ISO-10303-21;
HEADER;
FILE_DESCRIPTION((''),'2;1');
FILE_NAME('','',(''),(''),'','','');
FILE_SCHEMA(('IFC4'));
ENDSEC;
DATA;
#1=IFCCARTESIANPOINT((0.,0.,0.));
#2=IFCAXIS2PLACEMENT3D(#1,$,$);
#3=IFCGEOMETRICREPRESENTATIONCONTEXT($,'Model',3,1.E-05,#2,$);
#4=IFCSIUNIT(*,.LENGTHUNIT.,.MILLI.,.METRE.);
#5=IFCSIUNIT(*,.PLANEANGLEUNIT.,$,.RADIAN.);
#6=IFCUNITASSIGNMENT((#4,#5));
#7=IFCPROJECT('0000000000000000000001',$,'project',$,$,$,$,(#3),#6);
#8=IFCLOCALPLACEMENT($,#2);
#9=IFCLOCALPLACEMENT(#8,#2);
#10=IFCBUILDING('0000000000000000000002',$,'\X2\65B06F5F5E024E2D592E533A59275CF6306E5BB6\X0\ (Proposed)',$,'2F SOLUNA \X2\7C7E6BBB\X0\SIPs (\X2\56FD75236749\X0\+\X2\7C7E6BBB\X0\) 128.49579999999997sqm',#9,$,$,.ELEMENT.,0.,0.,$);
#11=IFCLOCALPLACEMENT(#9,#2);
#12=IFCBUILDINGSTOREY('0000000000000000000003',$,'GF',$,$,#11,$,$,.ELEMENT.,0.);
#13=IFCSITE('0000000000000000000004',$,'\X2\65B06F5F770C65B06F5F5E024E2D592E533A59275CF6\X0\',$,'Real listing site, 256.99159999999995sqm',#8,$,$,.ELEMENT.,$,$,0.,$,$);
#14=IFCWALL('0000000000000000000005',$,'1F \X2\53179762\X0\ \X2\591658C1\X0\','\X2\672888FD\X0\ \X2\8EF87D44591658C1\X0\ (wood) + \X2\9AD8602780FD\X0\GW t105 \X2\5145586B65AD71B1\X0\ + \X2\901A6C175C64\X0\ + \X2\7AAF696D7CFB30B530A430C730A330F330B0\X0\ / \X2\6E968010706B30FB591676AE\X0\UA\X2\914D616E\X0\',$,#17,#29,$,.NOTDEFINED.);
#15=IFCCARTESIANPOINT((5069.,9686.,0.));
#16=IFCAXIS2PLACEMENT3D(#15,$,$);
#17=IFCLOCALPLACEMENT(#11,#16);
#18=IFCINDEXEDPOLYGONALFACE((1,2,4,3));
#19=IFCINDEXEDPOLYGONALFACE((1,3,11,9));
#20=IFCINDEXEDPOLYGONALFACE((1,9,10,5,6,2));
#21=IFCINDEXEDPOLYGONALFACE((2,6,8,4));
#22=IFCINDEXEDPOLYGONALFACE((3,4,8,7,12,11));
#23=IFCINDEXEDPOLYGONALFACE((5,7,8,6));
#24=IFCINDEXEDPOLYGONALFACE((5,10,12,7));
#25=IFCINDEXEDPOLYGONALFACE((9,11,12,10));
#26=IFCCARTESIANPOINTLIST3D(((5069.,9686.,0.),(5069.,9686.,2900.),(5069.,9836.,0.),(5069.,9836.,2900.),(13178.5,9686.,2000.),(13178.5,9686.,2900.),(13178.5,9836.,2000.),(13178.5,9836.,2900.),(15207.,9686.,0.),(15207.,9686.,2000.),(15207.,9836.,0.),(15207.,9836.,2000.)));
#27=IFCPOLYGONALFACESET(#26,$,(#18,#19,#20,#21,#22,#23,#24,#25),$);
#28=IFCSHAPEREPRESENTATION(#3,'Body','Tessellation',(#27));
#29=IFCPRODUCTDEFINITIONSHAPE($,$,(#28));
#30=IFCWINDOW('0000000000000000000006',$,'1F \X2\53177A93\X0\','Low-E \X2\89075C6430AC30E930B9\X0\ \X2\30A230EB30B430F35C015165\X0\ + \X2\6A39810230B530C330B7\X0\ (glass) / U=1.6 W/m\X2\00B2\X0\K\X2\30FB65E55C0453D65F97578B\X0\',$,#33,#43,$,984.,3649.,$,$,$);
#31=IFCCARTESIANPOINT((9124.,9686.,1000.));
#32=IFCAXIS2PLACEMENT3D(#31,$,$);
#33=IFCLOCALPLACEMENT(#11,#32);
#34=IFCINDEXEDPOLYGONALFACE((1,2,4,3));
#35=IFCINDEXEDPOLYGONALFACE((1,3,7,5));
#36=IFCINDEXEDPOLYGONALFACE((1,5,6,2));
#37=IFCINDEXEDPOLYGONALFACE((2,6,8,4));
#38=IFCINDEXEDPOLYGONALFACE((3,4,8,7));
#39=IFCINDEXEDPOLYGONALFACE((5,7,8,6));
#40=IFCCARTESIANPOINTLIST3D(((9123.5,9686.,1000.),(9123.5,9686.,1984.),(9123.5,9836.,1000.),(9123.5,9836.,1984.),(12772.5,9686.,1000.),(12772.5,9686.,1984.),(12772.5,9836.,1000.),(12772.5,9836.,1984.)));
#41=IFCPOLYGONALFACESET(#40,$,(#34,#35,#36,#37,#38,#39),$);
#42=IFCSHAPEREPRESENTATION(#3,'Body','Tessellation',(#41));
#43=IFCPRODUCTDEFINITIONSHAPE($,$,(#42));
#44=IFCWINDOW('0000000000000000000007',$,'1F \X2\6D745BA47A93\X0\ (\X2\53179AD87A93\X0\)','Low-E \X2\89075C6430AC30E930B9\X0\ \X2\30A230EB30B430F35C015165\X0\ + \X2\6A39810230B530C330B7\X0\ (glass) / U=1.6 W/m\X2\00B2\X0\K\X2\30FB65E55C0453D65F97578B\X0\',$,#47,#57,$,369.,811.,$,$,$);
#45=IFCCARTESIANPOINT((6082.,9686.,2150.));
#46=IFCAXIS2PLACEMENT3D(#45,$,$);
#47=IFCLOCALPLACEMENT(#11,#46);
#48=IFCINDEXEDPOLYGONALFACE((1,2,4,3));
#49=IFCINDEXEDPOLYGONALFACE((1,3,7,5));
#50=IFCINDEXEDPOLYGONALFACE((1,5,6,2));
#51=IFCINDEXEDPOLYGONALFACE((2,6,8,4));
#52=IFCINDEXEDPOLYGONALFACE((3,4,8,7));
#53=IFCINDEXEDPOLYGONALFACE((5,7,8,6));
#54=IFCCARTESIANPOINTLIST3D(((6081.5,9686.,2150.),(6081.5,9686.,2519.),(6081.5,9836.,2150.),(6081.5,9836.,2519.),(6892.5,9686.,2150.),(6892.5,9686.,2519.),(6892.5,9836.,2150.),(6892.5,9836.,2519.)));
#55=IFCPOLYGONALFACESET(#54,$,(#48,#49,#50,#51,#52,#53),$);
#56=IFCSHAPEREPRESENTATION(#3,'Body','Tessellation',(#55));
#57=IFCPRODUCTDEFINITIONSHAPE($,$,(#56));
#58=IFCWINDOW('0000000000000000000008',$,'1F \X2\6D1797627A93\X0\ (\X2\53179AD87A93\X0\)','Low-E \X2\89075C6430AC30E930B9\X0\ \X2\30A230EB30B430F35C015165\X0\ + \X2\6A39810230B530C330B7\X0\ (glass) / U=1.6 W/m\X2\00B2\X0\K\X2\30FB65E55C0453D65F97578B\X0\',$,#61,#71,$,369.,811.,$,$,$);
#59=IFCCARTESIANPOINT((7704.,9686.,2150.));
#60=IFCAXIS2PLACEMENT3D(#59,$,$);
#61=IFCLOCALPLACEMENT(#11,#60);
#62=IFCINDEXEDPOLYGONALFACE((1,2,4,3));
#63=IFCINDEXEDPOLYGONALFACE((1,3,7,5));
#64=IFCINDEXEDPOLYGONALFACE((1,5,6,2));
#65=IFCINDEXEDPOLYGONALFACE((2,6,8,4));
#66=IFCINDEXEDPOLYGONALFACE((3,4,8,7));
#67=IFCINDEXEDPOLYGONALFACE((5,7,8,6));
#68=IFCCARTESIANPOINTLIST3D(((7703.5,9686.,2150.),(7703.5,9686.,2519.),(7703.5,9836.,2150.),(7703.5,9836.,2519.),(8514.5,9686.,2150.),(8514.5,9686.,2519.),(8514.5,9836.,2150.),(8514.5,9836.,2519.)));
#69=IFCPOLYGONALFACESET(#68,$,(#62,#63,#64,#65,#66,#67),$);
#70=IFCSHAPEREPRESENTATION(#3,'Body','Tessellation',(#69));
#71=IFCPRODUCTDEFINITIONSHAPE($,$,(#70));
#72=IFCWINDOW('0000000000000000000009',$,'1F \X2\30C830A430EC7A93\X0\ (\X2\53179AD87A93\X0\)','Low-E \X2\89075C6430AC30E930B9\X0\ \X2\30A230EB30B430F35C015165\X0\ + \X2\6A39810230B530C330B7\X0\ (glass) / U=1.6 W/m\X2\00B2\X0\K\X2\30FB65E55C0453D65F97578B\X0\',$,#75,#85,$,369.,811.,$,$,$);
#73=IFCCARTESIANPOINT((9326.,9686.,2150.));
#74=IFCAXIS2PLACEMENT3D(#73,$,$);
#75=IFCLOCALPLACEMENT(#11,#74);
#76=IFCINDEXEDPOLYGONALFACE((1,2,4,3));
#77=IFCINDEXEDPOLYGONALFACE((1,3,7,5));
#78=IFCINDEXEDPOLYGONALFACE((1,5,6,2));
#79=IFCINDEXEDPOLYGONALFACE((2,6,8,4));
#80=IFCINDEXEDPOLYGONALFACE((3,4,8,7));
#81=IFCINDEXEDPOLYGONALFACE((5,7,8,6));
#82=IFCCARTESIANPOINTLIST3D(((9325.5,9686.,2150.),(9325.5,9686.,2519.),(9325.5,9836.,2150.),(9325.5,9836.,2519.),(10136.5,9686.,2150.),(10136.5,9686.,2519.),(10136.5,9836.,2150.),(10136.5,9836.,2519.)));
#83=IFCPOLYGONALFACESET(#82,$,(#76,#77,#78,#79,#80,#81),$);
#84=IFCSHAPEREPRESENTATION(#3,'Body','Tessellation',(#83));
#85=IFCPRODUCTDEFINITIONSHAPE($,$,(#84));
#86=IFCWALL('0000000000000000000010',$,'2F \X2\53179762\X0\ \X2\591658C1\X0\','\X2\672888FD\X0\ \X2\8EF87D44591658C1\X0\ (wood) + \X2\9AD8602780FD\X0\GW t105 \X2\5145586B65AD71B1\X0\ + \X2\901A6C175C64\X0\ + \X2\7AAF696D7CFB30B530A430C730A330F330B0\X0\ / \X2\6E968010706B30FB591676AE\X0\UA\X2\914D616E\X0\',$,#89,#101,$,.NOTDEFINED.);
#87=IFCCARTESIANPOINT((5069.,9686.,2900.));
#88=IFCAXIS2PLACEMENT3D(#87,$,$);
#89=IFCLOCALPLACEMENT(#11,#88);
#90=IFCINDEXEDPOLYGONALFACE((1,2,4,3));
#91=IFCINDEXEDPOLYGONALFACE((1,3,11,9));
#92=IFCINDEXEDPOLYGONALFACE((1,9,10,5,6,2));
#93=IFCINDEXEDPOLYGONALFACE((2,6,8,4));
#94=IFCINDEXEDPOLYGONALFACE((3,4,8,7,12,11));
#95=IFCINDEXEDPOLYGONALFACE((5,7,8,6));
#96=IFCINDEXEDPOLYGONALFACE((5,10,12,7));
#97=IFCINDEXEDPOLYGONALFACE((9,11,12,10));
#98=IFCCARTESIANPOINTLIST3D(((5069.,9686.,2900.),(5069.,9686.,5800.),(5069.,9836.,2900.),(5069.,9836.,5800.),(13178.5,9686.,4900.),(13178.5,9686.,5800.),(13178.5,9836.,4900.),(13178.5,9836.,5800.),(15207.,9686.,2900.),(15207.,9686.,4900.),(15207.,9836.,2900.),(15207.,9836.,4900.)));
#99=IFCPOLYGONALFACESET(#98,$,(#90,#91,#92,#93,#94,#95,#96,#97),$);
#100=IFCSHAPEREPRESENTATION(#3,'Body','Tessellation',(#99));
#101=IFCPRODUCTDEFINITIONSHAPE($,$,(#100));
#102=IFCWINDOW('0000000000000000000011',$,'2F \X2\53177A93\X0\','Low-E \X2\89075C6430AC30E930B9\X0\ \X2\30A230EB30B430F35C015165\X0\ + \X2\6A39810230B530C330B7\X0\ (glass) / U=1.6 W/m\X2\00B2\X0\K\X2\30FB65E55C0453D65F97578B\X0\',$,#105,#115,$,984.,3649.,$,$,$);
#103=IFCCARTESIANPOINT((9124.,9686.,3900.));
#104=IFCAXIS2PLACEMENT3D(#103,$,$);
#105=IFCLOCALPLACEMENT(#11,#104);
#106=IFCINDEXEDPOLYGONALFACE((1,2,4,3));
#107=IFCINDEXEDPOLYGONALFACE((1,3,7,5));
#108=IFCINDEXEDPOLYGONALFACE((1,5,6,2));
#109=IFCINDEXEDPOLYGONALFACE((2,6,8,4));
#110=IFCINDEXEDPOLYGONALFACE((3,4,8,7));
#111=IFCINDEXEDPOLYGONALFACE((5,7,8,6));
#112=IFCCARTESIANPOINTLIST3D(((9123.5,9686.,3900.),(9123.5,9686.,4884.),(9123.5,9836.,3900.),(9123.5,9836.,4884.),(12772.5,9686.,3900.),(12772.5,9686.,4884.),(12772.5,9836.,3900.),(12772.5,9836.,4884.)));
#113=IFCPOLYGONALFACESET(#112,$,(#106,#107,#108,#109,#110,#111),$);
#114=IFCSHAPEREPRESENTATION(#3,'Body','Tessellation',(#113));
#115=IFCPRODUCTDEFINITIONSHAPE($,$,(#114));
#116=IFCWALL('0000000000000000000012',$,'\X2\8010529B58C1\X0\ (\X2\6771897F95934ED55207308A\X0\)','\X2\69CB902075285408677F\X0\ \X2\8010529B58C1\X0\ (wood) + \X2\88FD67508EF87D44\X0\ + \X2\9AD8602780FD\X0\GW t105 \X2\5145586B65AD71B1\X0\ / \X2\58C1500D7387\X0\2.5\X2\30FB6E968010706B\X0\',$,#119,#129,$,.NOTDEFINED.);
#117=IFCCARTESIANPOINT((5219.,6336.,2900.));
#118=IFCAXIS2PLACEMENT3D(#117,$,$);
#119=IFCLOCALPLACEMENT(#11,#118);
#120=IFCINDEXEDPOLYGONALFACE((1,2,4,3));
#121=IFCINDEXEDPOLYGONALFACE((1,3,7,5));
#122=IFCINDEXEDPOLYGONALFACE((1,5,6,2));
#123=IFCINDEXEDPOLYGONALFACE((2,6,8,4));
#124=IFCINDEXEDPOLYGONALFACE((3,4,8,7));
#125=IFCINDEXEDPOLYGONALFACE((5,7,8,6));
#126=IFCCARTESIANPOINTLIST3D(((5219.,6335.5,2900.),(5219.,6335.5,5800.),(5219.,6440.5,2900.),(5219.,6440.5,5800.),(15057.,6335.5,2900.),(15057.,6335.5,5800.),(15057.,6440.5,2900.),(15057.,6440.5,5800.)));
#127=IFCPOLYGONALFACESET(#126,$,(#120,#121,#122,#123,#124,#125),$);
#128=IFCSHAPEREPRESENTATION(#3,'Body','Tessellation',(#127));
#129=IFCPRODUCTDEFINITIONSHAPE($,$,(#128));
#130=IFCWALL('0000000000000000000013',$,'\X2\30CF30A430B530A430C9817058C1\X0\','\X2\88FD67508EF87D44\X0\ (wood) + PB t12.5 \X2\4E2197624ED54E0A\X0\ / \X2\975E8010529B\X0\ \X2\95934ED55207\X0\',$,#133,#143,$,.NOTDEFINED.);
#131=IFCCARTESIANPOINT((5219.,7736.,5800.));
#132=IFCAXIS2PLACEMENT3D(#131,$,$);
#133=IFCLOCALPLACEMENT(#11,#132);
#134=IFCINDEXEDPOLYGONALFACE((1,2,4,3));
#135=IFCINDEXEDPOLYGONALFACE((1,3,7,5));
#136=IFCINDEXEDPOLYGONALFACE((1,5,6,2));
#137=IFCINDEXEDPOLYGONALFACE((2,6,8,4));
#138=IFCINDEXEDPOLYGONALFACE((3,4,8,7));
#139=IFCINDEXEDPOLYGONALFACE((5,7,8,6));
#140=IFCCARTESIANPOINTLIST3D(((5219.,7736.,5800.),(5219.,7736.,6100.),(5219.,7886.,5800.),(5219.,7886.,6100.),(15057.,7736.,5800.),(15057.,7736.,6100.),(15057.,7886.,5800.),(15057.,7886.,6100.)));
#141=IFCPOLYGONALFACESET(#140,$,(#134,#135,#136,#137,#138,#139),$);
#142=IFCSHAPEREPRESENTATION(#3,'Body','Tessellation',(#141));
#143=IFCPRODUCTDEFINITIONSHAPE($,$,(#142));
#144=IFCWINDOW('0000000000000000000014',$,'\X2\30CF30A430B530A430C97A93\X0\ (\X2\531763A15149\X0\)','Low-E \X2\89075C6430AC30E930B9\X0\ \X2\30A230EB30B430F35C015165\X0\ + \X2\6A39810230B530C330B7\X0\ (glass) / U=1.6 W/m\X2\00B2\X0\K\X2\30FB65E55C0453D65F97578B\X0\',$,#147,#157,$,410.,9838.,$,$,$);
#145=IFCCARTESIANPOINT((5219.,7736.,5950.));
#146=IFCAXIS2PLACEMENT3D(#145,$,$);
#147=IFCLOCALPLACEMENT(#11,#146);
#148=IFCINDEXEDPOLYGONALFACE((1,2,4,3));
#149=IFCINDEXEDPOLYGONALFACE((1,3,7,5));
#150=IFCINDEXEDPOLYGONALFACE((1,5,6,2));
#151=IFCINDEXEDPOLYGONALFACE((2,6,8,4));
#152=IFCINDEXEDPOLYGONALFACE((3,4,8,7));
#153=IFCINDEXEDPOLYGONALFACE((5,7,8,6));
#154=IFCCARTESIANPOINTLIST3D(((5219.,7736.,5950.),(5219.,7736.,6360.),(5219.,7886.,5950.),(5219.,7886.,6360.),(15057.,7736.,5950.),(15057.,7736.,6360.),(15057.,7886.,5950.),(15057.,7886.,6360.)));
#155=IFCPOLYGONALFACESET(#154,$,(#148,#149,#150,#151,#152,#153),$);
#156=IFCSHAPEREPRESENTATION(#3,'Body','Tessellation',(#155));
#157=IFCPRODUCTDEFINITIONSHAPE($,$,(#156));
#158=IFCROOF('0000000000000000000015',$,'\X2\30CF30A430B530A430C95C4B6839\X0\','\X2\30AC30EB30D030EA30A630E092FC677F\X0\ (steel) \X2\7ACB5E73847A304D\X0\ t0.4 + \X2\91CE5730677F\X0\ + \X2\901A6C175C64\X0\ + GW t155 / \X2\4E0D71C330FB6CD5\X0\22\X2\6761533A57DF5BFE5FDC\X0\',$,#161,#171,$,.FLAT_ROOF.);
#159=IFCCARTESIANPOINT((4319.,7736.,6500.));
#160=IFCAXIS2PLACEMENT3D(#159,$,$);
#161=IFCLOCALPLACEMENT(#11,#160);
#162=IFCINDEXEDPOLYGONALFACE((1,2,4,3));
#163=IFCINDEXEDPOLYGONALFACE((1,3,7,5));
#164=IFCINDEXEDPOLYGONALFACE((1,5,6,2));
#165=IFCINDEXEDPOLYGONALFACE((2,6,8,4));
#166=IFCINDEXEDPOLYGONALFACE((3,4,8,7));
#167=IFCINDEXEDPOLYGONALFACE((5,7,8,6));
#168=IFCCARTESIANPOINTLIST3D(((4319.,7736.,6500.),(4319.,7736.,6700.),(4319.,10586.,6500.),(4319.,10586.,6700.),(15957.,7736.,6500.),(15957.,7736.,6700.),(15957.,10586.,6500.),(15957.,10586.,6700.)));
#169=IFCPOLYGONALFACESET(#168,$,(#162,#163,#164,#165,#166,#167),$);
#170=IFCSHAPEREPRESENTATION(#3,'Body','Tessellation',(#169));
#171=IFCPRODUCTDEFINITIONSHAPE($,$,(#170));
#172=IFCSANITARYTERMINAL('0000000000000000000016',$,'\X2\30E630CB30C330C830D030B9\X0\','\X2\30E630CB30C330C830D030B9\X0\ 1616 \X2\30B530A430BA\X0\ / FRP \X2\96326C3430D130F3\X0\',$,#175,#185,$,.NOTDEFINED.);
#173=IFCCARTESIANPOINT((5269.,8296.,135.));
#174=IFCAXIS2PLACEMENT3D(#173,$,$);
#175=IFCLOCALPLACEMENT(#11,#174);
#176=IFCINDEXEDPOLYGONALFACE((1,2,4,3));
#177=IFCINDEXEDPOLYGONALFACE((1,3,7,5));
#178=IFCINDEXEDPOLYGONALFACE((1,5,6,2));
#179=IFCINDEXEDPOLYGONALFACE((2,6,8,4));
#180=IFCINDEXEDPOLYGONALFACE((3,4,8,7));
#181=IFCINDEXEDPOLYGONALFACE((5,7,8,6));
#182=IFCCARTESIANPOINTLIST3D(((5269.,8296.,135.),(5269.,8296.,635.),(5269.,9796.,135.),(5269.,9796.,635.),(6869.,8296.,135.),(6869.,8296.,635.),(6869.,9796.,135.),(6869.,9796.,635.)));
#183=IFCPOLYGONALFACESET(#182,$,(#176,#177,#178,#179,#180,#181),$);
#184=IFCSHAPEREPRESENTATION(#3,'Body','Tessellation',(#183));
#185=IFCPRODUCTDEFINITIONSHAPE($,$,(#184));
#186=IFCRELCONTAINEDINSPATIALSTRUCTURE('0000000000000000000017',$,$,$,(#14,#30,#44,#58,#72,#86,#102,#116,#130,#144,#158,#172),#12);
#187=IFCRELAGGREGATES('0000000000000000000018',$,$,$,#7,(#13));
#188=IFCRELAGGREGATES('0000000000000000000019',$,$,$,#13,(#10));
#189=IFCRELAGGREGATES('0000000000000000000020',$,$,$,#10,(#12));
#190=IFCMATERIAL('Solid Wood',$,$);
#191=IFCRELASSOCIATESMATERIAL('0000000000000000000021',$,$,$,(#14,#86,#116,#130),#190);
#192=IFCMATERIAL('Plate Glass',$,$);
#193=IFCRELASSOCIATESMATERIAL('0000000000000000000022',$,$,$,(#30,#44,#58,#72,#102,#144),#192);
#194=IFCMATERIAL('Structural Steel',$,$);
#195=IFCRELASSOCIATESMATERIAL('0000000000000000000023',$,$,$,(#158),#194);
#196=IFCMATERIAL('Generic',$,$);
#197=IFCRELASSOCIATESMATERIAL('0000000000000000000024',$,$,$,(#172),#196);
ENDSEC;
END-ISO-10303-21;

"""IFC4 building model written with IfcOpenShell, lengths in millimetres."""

from ifc_helpers import new_model, si_unit, frame, frame_2d, origin, place, context, project, spatial, rectangle, extrude, material, element, fill, save


model = new_model("IFC4")

# Units and contexts
model_context = context("Model", 3, precision=1e-05, world=origin())
ifc_project = project(units=[si_unit("LENGTHUNIT", "METRE", prefix="MILLI"), si_unit("PLANEANGLEUNIT", "RADIAN")], contexts=[model_context])

# Site, building, storey
site_placement = place(None, origin())
site = spatial("IfcSite", under=ifc_project, at=site_placement, Name="新潟県新潟市中央区大島", ObjectType="Real listing site, 256.99159999999995sqm", CompositionType="ELEMENT", RefElevation=0.0)
building_placement = place(site_placement, origin())
building = spatial("IfcBuilding", under=site, at=building_placement, Name="新潟市中央区大島の家 (Proposed)", ObjectType="2F SOLUNA 籾殻SIPs (国産杉+籾殻) 128.49579999999997sqm", CompositionType="ELEMENT", ElevationOfRefHeight=0.0, ElevationOfTerrain=0.0)
storey_placement = place(building_placement, origin())
storey = spatial("IfcBuildingStorey", under=building, at=storey_placement, Name="GF", CompositionType="ELEMENT", Elevation=0.0)

# Wall, openings, windows
ifc_material_1 = material(Name="Solid Wood")
wall_1_placement = place(storey_placement, frame((5069.0, 9686.0, 0.0)))
wall_1 = element("IfcWall", 1, at=wall_1_placement, inside=storey, material=ifc_material_1, Name="1F 北面 外壁", Description="木製 軸組外壁 (wood) + 高性能GW t105 充填断熱 + 通気層 + 窯業系サイディング / 準耐火・外皮UA配慮", PredefinedType="NOTDEFINED", context=model_context, shape_type="SweptSolid", body=[
    extrude(rectangle(XDim=10138.0, YDim=150.0, at=frame_2d((5069.0, 75.0))), frame((5069.0, 9686.0, 0.0)), (0.0, 0.0, 1.0), 2900.0),
])
opening_1_placement = place(storey_placement, frame((9124.0, 9686.0, 1000.0)))
opening_1 = element("IfcOpeningElement", 2, at=opening_1_placement, cuts=wall_1, PredefinedType="NOTDEFINED", context=model_context, shape_type="SweptSolid", body=[
    extrude(rectangle(XDim=3649.0, YDim=150.0, at=frame_2d((1824.0, 75.0))), frame((9124.0, 9686.0, 1000.0)), (0.0, 0.0, 1.0), 984.0),
])
opening_2_placement = place(storey_placement, frame((6082.0, 9686.0, 2150.0)))
opening_2 = element("IfcOpeningElement", 3, at=opening_2_placement, cuts=wall_1, PredefinedType="NOTDEFINED", context=model_context, shape_type="SweptSolid", body=[
    extrude(rectangle(XDim=811.0, YDim=150.0, at=frame_2d((405.0, 75.0))), frame((6082.0, 9686.0, 2150.0)), (0.0, 0.0, 1.0), 369.0),
])
opening_3_placement = place(storey_placement, frame((7704.0, 9686.0, 2150.0)))
opening_3 = element("IfcOpeningElement", 4, at=opening_3_placement, cuts=wall_1, PredefinedType="NOTDEFINED", context=model_context, shape_type="SweptSolid", body=[
    extrude(rectangle(XDim=811.0, YDim=150.0, at=frame_2d((405.0, 75.0))), frame((7704.0, 9686.0, 2150.0)), (0.0, 0.0, 1.0), 369.0),
])
opening_4_placement = place(storey_placement, frame((9326.0, 9686.0, 2150.0)))
opening_4 = element("IfcOpeningElement", 5, at=opening_4_placement, cuts=wall_1, PredefinedType="NOTDEFINED", context=model_context, shape_type="SweptSolid", body=[
    extrude(rectangle(XDim=811.0, YDim=150.0, at=frame_2d((405.0, 75.0))), frame((9326.0, 9686.0, 2150.0)), (0.0, 0.0, 1.0), 369.0),
])
ifc_material_2 = material(Name="Plate Glass")
window_1_placement = place(storey_placement, frame((9124.0, 9686.0, 1000.0)))
window_1 = element("IfcWindow", 6, at=window_1_placement, inside=storey, material=ifc_material_2, Name="1F 北窓", Description="Low-E 複層ガラス アルゴン封入 + 樹脂サッシ (glass) / U=1.6 W/m²K・日射取得型", OverallHeight=984.0, OverallWidth=3649.0, context=model_context, shape_type="SweptSolid", body=[
    extrude(rectangle(XDim=3649.0, YDim=150.0, at=frame_2d((1824.0, 75.0))), frame((9124.0, 9686.0, 1000.0)), (0.0, 0.0, 1.0), 984.0),
])
fill(opening_1, window_1)
window_2_placement = place(storey_placement, frame((6082.0, 9686.0, 2150.0)))
window_2 = element("IfcWindow", 7, at=window_2_placement, inside=storey, material=ifc_material_2, Name="1F 浴室窓 (北高窓)", Description="Low-E 複層ガラス アルゴン封入 + 樹脂サッシ (glass) / U=1.6 W/m²K・日射取得型", OverallHeight=369.0, OverallWidth=811.0, context=model_context, shape_type="SweptSolid", body=[
    extrude(rectangle(XDim=811.0, YDim=150.0, at=frame_2d((405.0, 75.0))), frame((6082.0, 9686.0, 2150.0)), (0.0, 0.0, 1.0), 369.0),
])
fill(opening_2, window_2)
window_3_placement = place(storey_placement, frame((7704.0, 9686.0, 2150.0)))
window_3 = element("IfcWindow", 8, at=window_3_placement, inside=storey, material=ifc_material_2, Name="1F 洗面窓 (北高窓)", Description="Low-E 複層ガラス アルゴン封入 + 樹脂サッシ (glass) / U=1.6 W/m²K・日射取得型", OverallHeight=369.0, OverallWidth=811.0, context=model_context, shape_type="SweptSolid", body=[
    extrude(rectangle(XDim=811.0, YDim=150.0, at=frame_2d((405.0, 75.0))), frame((7704.0, 9686.0, 2150.0)), (0.0, 0.0, 1.0), 369.0),
])
fill(opening_3, window_3)
window_4_placement = place(storey_placement, frame((9326.0, 9686.0, 2150.0)))
window_4 = element("IfcWindow", 9, at=window_4_placement, inside=storey, material=ifc_material_2, Name="1F トイレ窓 (北高窓)", Description="Low-E 複層ガラス アルゴン封入 + 樹脂サッシ (glass) / U=1.6 W/m²K・日射取得型", OverallHeight=369.0, OverallWidth=811.0, context=model_context, shape_type="SweptSolid", body=[
    extrude(rectangle(XDim=811.0, YDim=150.0, at=frame_2d((405.0, 75.0))), frame((9326.0, 9686.0, 2150.0)), (0.0, 0.0, 1.0), 369.0),
])
fill(opening_4, window_4)

# Wall, opening, window
wall_2_placement = place(storey_placement, frame((5069.0, 9686.0, 2900.0)))
wall_2 = element("IfcWall", 10, at=wall_2_placement, inside=storey, material=ifc_material_1, Name="2F 北面 外壁", Description="木製 軸組外壁 (wood) + 高性能GW t105 充填断熱 + 通気層 + 窯業系サイディング / 準耐火・外皮UA配慮", PredefinedType="NOTDEFINED", context=model_context, shape_type="SweptSolid", body=[
    extrude(rectangle(XDim=10138.0, YDim=150.0, at=frame_2d((5069.0, 75.0))), frame((5069.0, 9686.0, 2900.0)), (0.0, 0.0, 1.0), 2900.0),
])
opening_5_placement = place(storey_placement, frame((9124.0, 9686.0, 3900.0)))
opening_5 = element("IfcOpeningElement", 11, at=opening_5_placement, cuts=wall_2, PredefinedType="NOTDEFINED", context=model_context, shape_type="SweptSolid", body=[
    extrude(rectangle(XDim=3649.0, YDim=150.0, at=frame_2d((1824.0, 75.0))), frame((9124.0, 9686.0, 3900.0)), (0.0, 0.0, 1.0), 984.0),
])
window_5_placement = place(storey_placement, frame((9124.0, 9686.0, 3900.0)))
window_5 = element("IfcWindow", 12, at=window_5_placement, inside=storey, material=ifc_material_2, Name="2F 北窓", Description="Low-E 複層ガラス アルゴン封入 + 樹脂サッシ (glass) / U=1.6 W/m²K・日射取得型", OverallHeight=984.0, OverallWidth=3649.0, context=model_context, shape_type="SweptSolid", body=[
    extrude(rectangle(XDim=3649.0, YDim=150.0, at=frame_2d((1824.0, 75.0))), frame((9124.0, 9686.0, 3900.0)), (0.0, 0.0, 1.0), 984.0),
])
fill(opening_5, window_5)

# Wall
wall_3_placement = place(storey_placement, frame((5219.0, 6336.0, 2900.0)))
element("IfcWall", 13, at=wall_3_placement, inside=storey, material=ifc_material_1, Name="耐力壁 (東西間仕切り)", Description="構造用合板 耐力壁 (wood) + 製材軸組 + 高性能GW t105 充填断熱 / 壁倍率2.5・準耐火", PredefinedType="NOTDEFINED", context=model_context, shape_type="SweptSolid", body=[
    extrude(rectangle(XDim=9838.0, YDim=105.0, at=frame_2d((4919.0, 52.0))), frame((5219.0, 6336.0, 2900.0)), (0.0, 0.0, 1.0), 2900.0),
])

# Wall, opening, window
wall_4_placement = place(storey_placement, frame((5219.0, 7736.0, 5800.0)))
wall_4 = element("IfcWall", 14, at=wall_4_placement, inside=storey, material=ifc_material_1, Name="ハイサイド腰壁", Description="製材軸組 (wood) + PB t12.5 両面仕上 / 非耐力 間仕切", PredefinedType="NOTDEFINED", context=model_context, shape_type="SweptSolid", body=[
    extrude(rectangle(XDim=9838.0, YDim=150.0, at=frame_2d((4919.0, 75.0))), frame((5219.0, 7736.0, 5800.0)), (0.0, 0.0, 1.0), 700.0),
])
opening_6_placement = place(storey_placement, frame((5219.0, 7736.0, 5950.0)))
opening_6 = element("IfcOpeningElement", 15, at=opening_6_placement, cuts=wall_4, PredefinedType="NOTDEFINED", context=model_context, shape_type="SweptSolid", body=[
    extrude(rectangle(XDim=9838.0, YDim=150.0, at=frame_2d((4919.0, 75.0))), frame((5219.0, 7736.0, 5950.0)), (0.0, 0.0, 1.0), 410.0),
])
window_6_placement = place(storey_placement, frame((5219.0, 7736.0, 5950.0)))
window_6 = element("IfcWindow", 16, at=window_6_placement, inside=storey, material=ifc_material_2, Name="ハイサイド窓 (北採光)", Description="Low-E 複層ガラス アルゴン封入 + 樹脂サッシ (glass) / U=1.6 W/m²K・日射取得型", OverallHeight=410.0, OverallWidth=9838.0, context=model_context, shape_type="SweptSolid", body=[
    extrude(rectangle(XDim=9838.0, YDim=150.0, at=frame_2d((4919.0, 75.0))), frame((5219.0, 7736.0, 5950.0)), (0.0, 0.0, 1.0), 410.0),
])
fill(opening_6, window_6)

# Roof
ifc_material_3 = material(Name="Structural Steel")
roof_placement = place(storey_placement, frame((4319.0, 7736.0, 6500.0)))
element("IfcRoof", 17, at=roof_placement, inside=storey, material=ifc_material_3, Name="ハイサイド屋根", Description="ガルバリウム鋼板 (steel) 立平葺き t0.4 + 野地板 + 通気層 + GW t155 / 不燃・法22条区域対応", PredefinedType="FLAT_ROOF", context=model_context, shape_type="SweptSolid", body=[
    extrude(rectangle(XDim=11638.0, YDim=2850.0, at=frame_2d((5819.0, 1425.0))), frame((4319.0, 7736.0, 6500.0)), (0.0, 0.0, 1.0), 200.0),
])

# Sanitary terminal
ifc_material_4 = material(Name="Generic")
sanitary_terminal_placement = place(storey_placement, frame((5269.0, 8296.0, 135.0)))
element("IfcSanitaryTerminal", 18, at=sanitary_terminal_placement, inside=storey, material=ifc_material_4, Name="ユニットバス", Description="ユニットバス 1616 サイズ / FRP 防水パン", PredefinedType="NOTDEFINED", context=model_context, shape_type="SweptSolid", body=[
    extrude(rectangle(XDim=1600.0, YDim=1500.0, at=frame_2d((800.0, 750.0))), frame((5269.0, 8296.0, 135.0)), (0.0, 0.0, 1.0), 500.0),
])

save(model, "model.ifc")
